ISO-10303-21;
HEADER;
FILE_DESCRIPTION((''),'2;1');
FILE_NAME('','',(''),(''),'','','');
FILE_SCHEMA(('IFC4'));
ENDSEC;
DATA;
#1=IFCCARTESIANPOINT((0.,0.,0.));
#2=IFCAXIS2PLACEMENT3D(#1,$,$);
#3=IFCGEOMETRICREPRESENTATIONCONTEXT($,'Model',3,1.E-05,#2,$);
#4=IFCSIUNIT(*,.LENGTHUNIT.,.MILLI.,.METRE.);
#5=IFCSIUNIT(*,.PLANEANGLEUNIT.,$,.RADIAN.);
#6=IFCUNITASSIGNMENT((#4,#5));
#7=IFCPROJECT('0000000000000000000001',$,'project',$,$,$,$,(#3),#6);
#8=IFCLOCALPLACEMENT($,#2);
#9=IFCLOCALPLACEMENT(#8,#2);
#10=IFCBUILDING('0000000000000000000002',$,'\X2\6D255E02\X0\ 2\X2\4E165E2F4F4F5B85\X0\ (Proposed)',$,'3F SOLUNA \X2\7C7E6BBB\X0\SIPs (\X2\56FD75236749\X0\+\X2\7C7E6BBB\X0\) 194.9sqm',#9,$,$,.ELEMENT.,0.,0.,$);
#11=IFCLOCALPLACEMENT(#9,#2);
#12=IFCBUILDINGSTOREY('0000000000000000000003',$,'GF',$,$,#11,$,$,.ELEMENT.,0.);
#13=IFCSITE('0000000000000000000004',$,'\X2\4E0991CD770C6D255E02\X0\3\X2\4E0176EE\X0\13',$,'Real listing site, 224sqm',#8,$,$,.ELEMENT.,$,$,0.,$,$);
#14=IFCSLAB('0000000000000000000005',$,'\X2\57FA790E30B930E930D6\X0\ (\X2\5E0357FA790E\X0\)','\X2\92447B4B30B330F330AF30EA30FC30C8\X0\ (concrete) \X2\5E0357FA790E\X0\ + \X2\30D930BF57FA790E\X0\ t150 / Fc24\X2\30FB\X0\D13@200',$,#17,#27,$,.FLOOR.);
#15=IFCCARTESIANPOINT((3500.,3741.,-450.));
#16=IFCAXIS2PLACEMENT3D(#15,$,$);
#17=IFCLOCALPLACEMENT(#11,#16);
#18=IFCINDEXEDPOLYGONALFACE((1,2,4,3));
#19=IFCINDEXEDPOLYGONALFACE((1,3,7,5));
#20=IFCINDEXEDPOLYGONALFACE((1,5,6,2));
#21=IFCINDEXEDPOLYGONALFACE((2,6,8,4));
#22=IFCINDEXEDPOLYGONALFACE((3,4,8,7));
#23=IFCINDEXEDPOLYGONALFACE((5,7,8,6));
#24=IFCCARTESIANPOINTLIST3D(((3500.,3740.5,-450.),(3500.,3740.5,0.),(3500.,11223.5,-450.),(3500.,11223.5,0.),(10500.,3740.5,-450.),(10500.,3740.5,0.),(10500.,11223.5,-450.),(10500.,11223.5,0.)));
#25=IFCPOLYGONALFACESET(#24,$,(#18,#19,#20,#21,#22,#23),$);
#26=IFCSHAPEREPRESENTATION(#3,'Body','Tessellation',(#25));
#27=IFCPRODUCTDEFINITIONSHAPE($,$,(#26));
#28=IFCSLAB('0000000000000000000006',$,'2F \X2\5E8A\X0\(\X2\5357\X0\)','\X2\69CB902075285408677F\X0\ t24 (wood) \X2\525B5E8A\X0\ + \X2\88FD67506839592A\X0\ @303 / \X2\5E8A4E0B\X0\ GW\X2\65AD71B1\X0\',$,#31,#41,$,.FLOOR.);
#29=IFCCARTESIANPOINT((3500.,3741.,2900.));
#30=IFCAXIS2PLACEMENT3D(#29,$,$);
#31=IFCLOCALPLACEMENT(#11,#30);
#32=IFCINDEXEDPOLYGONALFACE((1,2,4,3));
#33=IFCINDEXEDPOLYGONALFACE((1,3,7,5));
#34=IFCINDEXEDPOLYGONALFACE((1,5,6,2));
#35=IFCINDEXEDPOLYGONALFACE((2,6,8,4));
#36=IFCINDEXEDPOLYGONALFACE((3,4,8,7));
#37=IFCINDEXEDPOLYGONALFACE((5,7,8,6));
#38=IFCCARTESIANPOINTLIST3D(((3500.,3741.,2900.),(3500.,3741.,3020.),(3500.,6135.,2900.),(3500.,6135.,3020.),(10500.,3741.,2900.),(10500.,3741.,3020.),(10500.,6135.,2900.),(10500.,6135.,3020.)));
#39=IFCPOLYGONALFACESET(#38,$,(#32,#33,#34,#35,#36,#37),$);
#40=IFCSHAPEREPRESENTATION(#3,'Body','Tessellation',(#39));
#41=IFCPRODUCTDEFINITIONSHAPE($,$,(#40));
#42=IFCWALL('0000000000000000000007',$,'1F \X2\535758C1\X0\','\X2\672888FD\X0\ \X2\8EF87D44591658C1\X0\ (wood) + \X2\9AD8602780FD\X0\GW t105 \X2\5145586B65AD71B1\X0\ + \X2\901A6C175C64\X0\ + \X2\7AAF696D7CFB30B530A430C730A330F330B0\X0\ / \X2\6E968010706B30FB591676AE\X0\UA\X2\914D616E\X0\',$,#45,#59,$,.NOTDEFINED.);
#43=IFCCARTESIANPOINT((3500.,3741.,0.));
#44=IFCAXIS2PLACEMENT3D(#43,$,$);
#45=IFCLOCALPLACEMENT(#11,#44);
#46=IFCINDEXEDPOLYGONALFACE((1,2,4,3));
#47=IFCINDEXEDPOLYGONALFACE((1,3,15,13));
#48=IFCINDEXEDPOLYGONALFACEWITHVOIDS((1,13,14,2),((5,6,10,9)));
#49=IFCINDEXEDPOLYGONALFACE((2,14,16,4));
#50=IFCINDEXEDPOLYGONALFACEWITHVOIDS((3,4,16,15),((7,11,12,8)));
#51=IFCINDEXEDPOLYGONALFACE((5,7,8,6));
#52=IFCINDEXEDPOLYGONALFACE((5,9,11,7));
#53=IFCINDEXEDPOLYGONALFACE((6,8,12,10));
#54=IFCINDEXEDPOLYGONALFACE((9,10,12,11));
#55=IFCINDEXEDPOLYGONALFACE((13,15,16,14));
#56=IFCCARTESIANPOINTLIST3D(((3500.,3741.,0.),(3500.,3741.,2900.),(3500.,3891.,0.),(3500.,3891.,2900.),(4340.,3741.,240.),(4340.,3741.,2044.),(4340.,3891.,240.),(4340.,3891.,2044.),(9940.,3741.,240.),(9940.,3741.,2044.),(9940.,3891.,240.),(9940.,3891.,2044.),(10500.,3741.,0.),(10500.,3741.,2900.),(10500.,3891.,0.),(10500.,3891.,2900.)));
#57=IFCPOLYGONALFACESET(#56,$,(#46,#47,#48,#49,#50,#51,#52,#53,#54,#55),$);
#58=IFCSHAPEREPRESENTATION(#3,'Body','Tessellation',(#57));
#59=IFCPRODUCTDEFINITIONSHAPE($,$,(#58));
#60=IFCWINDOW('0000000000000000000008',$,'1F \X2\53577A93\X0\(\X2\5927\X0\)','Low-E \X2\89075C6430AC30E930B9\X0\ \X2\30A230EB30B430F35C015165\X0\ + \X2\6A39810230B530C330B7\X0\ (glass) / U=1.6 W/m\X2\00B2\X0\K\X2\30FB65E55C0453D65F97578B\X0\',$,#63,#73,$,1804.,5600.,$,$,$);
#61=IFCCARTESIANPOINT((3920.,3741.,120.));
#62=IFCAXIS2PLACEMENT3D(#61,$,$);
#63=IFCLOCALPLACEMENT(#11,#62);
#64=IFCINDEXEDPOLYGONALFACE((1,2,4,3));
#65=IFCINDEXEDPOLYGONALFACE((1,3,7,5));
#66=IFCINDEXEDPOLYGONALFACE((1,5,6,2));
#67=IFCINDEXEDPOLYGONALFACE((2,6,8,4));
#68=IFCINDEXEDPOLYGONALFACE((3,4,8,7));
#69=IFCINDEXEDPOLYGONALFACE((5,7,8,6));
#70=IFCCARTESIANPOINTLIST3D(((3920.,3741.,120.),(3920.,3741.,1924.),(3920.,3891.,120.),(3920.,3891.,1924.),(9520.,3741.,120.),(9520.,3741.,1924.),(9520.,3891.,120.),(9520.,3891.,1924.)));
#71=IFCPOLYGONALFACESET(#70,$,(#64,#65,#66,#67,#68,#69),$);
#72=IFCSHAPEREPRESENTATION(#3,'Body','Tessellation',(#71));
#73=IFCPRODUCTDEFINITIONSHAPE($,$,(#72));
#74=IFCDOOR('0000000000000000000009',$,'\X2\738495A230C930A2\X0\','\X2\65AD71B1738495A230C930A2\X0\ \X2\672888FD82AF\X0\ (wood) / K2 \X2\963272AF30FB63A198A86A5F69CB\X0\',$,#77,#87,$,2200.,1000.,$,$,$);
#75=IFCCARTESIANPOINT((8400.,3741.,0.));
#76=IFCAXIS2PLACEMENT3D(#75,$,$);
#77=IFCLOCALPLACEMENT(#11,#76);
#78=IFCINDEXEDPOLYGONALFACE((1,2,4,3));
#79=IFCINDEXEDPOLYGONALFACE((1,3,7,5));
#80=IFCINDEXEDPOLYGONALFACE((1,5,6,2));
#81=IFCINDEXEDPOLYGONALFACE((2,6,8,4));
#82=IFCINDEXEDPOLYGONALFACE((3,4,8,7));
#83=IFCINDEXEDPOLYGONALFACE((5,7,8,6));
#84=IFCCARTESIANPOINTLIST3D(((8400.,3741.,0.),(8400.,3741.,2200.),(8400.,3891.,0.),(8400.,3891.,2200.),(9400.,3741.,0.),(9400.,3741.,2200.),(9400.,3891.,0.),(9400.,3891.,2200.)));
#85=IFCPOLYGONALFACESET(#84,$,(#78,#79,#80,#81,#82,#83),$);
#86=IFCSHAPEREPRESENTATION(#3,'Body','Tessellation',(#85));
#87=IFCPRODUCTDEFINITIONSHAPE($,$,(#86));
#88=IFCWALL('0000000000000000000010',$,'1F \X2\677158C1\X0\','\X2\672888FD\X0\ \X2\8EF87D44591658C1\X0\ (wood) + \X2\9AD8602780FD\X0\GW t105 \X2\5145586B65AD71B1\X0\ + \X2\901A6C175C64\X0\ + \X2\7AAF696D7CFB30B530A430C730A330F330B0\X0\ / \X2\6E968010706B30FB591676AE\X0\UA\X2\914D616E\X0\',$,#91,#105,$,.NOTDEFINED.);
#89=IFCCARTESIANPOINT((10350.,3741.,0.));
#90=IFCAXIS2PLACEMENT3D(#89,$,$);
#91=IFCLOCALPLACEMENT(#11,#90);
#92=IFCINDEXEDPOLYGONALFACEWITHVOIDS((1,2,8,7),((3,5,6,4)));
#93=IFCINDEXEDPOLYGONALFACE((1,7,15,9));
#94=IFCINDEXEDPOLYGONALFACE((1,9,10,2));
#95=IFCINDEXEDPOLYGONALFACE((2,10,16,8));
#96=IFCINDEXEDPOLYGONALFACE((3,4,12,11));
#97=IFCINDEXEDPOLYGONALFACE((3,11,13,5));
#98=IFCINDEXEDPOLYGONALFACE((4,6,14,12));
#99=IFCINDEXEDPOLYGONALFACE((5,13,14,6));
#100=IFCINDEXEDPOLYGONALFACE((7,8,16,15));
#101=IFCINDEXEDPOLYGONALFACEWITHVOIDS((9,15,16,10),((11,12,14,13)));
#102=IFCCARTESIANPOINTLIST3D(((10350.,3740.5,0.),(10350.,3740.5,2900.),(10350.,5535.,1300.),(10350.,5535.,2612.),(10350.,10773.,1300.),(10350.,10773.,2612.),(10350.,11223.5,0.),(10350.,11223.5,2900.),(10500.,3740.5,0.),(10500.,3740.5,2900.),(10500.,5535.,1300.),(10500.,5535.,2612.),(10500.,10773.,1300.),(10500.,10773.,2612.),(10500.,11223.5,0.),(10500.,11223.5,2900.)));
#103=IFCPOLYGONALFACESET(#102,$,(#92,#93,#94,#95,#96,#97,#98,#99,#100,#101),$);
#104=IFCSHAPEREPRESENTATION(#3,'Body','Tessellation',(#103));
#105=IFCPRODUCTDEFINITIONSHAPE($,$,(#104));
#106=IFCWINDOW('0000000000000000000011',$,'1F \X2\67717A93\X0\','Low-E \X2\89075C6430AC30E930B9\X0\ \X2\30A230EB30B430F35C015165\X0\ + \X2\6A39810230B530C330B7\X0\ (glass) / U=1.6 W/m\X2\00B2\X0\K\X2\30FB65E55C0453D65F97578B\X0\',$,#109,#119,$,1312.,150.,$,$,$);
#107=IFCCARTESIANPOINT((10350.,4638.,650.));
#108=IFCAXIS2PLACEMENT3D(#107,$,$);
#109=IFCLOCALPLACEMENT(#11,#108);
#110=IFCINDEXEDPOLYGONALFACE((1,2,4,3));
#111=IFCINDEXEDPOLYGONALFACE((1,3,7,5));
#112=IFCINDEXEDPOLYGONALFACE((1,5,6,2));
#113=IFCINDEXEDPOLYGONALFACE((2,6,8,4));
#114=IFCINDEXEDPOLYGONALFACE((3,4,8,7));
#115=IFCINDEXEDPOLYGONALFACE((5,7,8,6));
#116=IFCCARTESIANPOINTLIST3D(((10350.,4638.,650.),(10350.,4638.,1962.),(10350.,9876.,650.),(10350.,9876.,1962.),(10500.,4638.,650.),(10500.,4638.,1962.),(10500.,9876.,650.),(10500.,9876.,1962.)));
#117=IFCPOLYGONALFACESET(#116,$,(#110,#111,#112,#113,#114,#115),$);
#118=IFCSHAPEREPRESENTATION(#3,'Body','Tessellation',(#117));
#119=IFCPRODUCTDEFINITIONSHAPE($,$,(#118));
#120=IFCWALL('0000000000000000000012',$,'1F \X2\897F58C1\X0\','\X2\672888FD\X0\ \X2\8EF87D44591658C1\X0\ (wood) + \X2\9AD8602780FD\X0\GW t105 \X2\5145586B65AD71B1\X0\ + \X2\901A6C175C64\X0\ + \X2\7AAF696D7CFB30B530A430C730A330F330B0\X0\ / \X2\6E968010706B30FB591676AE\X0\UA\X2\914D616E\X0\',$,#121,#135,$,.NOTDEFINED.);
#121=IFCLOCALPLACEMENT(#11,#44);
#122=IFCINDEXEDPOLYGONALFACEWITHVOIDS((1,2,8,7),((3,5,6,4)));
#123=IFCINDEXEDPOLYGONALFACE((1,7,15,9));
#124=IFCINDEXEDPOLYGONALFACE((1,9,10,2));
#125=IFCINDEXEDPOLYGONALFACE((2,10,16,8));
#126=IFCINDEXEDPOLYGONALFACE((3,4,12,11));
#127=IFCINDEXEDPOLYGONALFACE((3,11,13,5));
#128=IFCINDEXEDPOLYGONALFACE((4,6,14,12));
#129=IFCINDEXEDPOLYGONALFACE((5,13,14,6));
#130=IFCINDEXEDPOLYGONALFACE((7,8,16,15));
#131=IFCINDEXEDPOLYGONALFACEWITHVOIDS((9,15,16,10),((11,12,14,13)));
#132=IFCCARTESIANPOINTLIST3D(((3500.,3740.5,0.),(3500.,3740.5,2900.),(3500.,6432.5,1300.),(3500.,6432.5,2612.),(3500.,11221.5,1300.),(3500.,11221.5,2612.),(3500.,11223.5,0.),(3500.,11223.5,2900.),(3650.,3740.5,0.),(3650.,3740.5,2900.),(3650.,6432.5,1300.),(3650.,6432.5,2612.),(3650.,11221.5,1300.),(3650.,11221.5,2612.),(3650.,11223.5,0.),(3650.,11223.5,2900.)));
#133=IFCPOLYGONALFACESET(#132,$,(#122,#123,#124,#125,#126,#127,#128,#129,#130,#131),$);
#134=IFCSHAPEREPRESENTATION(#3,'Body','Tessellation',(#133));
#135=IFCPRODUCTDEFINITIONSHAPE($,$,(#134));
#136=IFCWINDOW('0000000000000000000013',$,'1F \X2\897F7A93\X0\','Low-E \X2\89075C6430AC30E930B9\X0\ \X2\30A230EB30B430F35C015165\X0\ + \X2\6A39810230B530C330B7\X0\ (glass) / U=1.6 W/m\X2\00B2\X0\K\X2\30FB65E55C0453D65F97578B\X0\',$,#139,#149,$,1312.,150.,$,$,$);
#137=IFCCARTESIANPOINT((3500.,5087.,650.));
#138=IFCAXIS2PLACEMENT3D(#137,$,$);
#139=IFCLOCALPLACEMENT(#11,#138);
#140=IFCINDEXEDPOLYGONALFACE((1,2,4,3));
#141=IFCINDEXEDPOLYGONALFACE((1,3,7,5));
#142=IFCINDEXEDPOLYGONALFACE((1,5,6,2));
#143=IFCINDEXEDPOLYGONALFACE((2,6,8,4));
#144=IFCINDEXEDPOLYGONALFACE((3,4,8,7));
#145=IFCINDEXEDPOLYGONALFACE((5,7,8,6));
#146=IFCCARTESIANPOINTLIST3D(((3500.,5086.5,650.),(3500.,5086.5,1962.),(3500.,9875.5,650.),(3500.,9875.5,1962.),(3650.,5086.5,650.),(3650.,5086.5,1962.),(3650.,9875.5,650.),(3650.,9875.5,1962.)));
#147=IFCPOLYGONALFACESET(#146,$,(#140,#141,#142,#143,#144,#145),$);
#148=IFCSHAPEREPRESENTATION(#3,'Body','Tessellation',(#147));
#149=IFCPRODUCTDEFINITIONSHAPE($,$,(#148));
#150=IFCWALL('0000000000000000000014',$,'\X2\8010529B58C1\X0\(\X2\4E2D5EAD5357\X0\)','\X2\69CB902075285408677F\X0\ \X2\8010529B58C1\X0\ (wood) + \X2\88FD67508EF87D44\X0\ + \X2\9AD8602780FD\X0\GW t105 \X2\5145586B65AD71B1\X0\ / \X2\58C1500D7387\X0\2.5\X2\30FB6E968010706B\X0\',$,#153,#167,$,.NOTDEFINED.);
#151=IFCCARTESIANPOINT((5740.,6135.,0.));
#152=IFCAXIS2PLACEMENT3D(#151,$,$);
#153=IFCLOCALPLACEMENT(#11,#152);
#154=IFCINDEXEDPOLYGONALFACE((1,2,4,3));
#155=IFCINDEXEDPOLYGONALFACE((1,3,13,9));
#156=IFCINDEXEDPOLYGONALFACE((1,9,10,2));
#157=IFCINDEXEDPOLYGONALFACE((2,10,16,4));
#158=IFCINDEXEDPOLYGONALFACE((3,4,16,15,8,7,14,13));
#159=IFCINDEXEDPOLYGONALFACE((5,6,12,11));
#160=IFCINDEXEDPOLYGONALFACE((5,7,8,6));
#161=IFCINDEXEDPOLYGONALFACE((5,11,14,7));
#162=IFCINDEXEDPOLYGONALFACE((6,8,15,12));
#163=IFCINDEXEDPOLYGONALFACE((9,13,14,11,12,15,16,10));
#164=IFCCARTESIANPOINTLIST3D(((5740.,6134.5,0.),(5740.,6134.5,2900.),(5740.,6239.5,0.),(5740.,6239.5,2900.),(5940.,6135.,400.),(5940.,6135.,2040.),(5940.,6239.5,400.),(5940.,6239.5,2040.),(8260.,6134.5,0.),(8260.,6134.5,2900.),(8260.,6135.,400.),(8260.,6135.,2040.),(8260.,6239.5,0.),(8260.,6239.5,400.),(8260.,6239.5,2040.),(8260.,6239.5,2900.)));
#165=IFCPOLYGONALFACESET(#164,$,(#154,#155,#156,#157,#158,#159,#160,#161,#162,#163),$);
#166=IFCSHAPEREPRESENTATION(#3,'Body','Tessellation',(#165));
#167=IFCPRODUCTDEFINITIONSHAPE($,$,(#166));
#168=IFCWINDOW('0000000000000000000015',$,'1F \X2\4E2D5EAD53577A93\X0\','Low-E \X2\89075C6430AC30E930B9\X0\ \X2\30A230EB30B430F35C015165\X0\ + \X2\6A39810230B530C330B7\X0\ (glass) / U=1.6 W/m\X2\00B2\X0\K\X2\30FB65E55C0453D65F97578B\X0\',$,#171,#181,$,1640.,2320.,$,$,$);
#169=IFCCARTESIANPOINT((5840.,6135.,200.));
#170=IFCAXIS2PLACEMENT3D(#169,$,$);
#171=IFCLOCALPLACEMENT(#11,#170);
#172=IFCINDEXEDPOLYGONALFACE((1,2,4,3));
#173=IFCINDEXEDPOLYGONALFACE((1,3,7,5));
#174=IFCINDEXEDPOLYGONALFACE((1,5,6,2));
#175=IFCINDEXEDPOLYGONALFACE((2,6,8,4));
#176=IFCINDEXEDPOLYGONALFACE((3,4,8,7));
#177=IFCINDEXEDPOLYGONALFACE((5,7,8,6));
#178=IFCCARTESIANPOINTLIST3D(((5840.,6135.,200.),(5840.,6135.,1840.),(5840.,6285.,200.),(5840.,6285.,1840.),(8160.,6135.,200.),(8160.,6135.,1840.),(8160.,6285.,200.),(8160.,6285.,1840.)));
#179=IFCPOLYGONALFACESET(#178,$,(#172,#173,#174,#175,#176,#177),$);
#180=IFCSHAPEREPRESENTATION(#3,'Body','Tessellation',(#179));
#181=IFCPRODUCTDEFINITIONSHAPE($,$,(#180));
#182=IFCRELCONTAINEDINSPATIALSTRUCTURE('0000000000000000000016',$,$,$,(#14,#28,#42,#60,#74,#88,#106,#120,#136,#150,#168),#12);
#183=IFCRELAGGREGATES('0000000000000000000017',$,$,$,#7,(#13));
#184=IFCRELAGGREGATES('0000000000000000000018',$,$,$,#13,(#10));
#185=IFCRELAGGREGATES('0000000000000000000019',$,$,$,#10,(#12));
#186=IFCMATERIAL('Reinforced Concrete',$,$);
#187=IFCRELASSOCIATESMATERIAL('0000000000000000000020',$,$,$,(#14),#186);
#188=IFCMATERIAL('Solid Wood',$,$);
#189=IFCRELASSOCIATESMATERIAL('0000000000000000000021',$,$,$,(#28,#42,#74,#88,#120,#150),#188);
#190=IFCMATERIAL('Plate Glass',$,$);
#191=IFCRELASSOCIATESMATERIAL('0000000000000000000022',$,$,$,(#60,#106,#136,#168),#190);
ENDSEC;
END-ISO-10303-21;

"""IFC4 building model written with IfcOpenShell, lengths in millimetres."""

from ifc_helpers import new_model, si_unit, frame, frame_2d, origin, place, context, project, spatial, rectangle, extrude, material, element, fill, save


model = new_model("IFC4")

# Units and contexts
model_context = context("Model", 3, precision=1e-05, world=origin())
ifc_project = project(units=[si_unit("LENGTHUNIT", "METRE", prefix="MILLI"), si_unit("PLANEANGLEUNIT", "RADIAN")], contexts=[model_context])

# Site, building, storey
site_placement = place(None, origin())
site = spatial("IfcSite", under=ifc_project, at=site_placement, Name="三重県津市3丁目13", ObjectType="Real listing site, 224sqm", CompositionType="ELEMENT", RefElevation=0.0)
building_placement = place(site_placement, origin())
building = spatial("IfcBuilding", under=site, at=building_placement, Name="津市 2世帯住宅 (Proposed)", ObjectType="3F SOLUNA 籾殻SIPs (国産杉+籾殻) 194.9sqm", CompositionType="ELEMENT", ElevationOfRefHeight=0.0, ElevationOfTerrain=0.0)
storey_placement = place(building_placement, origin())
storey = spatial("IfcBuildingStorey", under=building, at=storey_placement, Name="GF", CompositionType="ELEMENT", Elevation=0.0)

# Slabs
ifc_material_1 = material(Name="Reinforced Concrete")
slab_1_placement = place(storey_placement, frame((3500.0, 3741.0, -450.0)))
element("IfcSlab", 1, at=slab_1_placement, inside=storey, material=ifc_material_1, Name="基礎スラブ (布基礎)", Description="鉄筋コンクリート (concrete) 布基礎 + ベタ基礎 t150 / Fc24・D13@200", PredefinedType="FLOOR", context=model_context, shape_type="SweptSolid", body=[
    extrude(rectangle(XDim=7000.0, YDim=7483.0, at=frame_2d((3500.0, 3741.0))), frame((3500.0, 3741.0, -450.0)), (0.0, 0.0, 1.0), 450.0),
])
ifc_material_2 = material(Name="Solid Wood")
slab_2_placement = place(storey_placement, frame((3500.0, 3741.0, 2900.0)))
element("IfcSlab", 2, at=slab_2_placement, inside=storey, material=ifc_material_2, Name="2F 床(南)", Description="構造用合板 t24 (wood) 剛床 + 製材根太 @303 / 床下 GW断熱", PredefinedType="FLOOR", context=model_context, shape_type="SweptSolid", body=[
    extrude(rectangle(XDim=7000.0, YDim=2394.0, at=frame_2d((3500.0, 1197.0))), frame((3500.0, 3741.0, 2900.0)), (0.0, 0.0, 1.0), 120.0),
])

# Wall, openings, window, door
wall_1_placement = place(storey_placement, frame((3500.0, 3741.0, 0.0)))
wall_1 = element("IfcWall", 3, at=wall_1_placement, inside=storey, material=ifc_material_2, Name="1F 南壁", Description="木製 軸組外壁 (wood) + 高性能GW t105 充填断熱 + 通気層 + 窯業系サイディング / 準耐火・外皮UA配慮", PredefinedType="NOTDEFINED", context=model_context, shape_type="SweptSolid", body=[
    extrude(rectangle(XDim=7000.0, YDim=150.0, at=frame_2d((3500.0, 75.0))), frame((3500.0, 3741.0, 0.0)), (0.0, 0.0, 1.0), 2900.0),
])
opening_1_placement = place(storey_placement, frame((3920.0, 3741.0, 120.0)))
opening_1 = element("IfcOpeningElement", 4, at=opening_1_placement, cuts=wall_1, PredefinedType="NOTDEFINED", context=model_context, shape_type="SweptSolid", body=[
    extrude(rectangle(XDim=5600.0, YDim=150.0, at=frame_2d((2800.0, 75.0))), frame((3920.0, 3741.0, 120.0)), (0.0, 0.0, 1.0), 1804.0),
])
opening_2_placement = place(storey_placement, frame((8400.0, 3741.0, 0.0)))
opening_2 = element("IfcOpeningElement", 5, at=opening_2_placement, cuts=wall_1, PredefinedType="NOTDEFINED", context=model_context, shape_type="SweptSolid", body=[
    extrude(rectangle(XDim=1000.0, YDim=150.0, at=frame_2d((500.0, 75.0))), frame((8400.0, 3741.0, 0.0)), (0.0, 0.0, 1.0), 2200.0),
])
ifc_material_3 = material(Name="Plate Glass")
window_1_placement = place(storey_placement, frame((3920.0, 3741.0, 120.0)))
window_1 = element("IfcWindow", 6, at=window_1_placement, inside=storey, material=ifc_material_3, Name="1F 南窓(大)", Description="Low-E 複層ガラス アルゴン封入 + 樹脂サッシ (glass) / U=1.6 W/m²K・日射取得型", OverallHeight=1804.0, OverallWidth=5600.0, context=model_context, shape_type="SweptSolid", body=[
    extrude(rectangle(XDim=5600.0, YDim=150.0, at=frame_2d((2800.0, 75.0))), frame((3920.0, 3741.0, 120.0)), (0.0, 0.0, 1.0), 1804.0),
])
fill(opening_1, window_1)
door_placement = place(storey_placement, frame((8400.0, 3741.0, 0.0)))
door = element("IfcDoor", 7, at=door_placement, inside=storey, material=ifc_material_2, Name="玄関ドア", Description="断熱玄関ドア 木製芯 (wood) / K2 防犯・採風機構", OverallHeight=2200.0, OverallWidth=1000.0, context=model_context, shape_type="SweptSolid", body=[
    extrude(rectangle(XDim=1000.0, YDim=150.0, at=frame_2d((500.0, 75.0))), frame((8400.0, 3741.0, 0.0)), (0.0, 0.0, 1.0), 2200.0),
])
fill(opening_2, door)

# Walls, openings, windows
wall_2_placement = place(storey_placement, frame((10350.0, 3741.0, 0.0)))
wall_2 = element("IfcWall", 8, at=wall_2_placement, inside=storey, material=ifc_material_2, Name="1F 東壁", Description="木製 軸組外壁 (wood) + 高性能GW t105 充填断熱 + 通気層 + 窯業系サイディング / 準耐火・外皮UA配慮", PredefinedType="NOTDEFINED", context=model_context, shape_type="SweptSolid", body=[
    extrude(rectangle(XDim=150.0, YDim=7483.0, at=frame_2d((75.0, 3741.0))), frame((10350.0, 3741.0, 0.0)), (0.0, 0.0, 1.0), 2900.0),
])
opening_3_placement = place(storey_placement, frame((10350.0, 4638.0, 650.0)))
opening_3 = element("IfcOpeningElement", 9, at=opening_3_placement, cuts=wall_2, PredefinedType="NOTDEFINED", context=model_context, shape_type="SweptSolid", body=[
    extrude(rectangle(XDim=150.0, YDim=5238.0, at=frame_2d((75.0, 2619.0))), frame((10350.0, 4638.0, 650.0)), (0.0, 0.0, 1.0), 1312.0),
])
window_2_placement = place(storey_placement, frame((10350.0, 4638.0, 650.0)))
window_2 = element("IfcWindow", 10, at=window_2_placement, inside=storey, material=ifc_material_3, Name="1F 東窓", Description="Low-E 複層ガラス アルゴン封入 + 樹脂サッシ (glass) / U=1.6 W/m²K・日射取得型", OverallHeight=1312.0, OverallWidth=150.0, context=model_context, shape_type="SweptSolid", body=[
    extrude(rectangle(XDim=150.0, YDim=5238.0, at=frame_2d((75.0, 2619.0))), frame((10350.0, 4638.0, 650.0)), (0.0, 0.0, 1.0), 1312.0),
])
fill(opening_3, window_2)
wall_3_placement = place(storey_placement, frame((3500.0, 3741.0, 0.0)))
wall_3 = element("IfcWall", 11, at=wall_3_placement, inside=storey, material=ifc_material_2, Name="1F 西壁", Description="木製 軸組外壁 (wood) + 高性能GW t105 充填断熱 + 通気層 + 窯業系サイディング / 準耐火・外皮UA配慮", PredefinedType="NOTDEFINED", context=model_context, shape_type="SweptSolid", body=[
    extrude(rectangle(XDim=150.0, YDim=7483.0, at=frame_2d((75.0, 3741.0))), frame((3500.0, 3741.0, 0.0)), (0.0, 0.0, 1.0), 2900.0),
])
opening_4_placement = place(storey_placement, frame((3500.0, 5087.0, 650.0)))
opening_4 = element("IfcOpeningElement", 12, at=opening_4_placement, cuts=wall_3, PredefinedType="NOTDEFINED", context=model_context, shape_type="SweptSolid", body=[
    extrude(rectangle(XDim=150.0, YDim=4789.0, at=frame_2d((75.0, 2394.0))), frame((3500.0, 5087.0, 650.0)), (0.0, 0.0, 1.0), 1312.0),
])
window_3_placement = place(storey_placement, frame((3500.0, 5087.0, 650.0)))
window_3 = element("IfcWindow", 13, at=window_3_placement, inside=storey, material=ifc_material_3, Name="1F 西窓", Description="Low-E 複層ガラス アルゴン封入 + 樹脂サッシ (glass) / U=1.6 W/m²K・日射取得型", OverallHeight=1312.0, OverallWidth=150.0, context=model_context, shape_type="SweptSolid", body=[
    extrude(rectangle(XDim=150.0, YDim=4789.0, at=frame_2d((75.0, 2394.0))), frame((3500.0, 5087.0, 650.0)), (0.0, 0.0, 1.0), 1312.0),
])
fill(opening_4, window_3)
wall_4_placement = place(storey_placement, frame((5740.0, 6135.0, 0.0)))
wall_4 = element("IfcWall", 14, at=wall_4_placement, inside=storey, material=ifc_material_2, Name="耐力壁(中庭南)", Description="構造用合板 耐力壁 (wood) + 製材軸組 + 高性能GW t105 充填断熱 / 壁倍率2.5・準耐火", PredefinedType="NOTDEFINED", context=model_context, shape_type="SweptSolid", body=[
    extrude(rectangle(XDim=2520.0, YDim=105.0, at=frame_2d((1260.0, 52.0))), frame((5740.0, 6135.0, 0.0)), (0.0, 0.0, 1.0), 2900.0),
])
opening_5_placement = place(storey_placement, frame((5840.0, 6135.0, 200.0)))
opening_5 = element("IfcOpeningElement", 15, at=opening_5_placement, cuts=wall_4, PredefinedType="NOTDEFINED", context=model_context, shape_type="SweptSolid", body=[
    extrude(rectangle(XDim=2320.0, YDim=150.0, at=frame_2d((1160.0, 75.0))), frame((5840.0, 6135.0, 200.0)), (0.0, 0.0, 1.0), 1640.0),
])
window_4_placement = place(storey_placement, frame((5840.0, 6135.0, 200.0)))
window_4 = element("IfcWindow", 16, at=window_4_placement, inside=storey, material=ifc_material_3, Name="1F 中庭南窓", Description="Low-E 複層ガラス アルゴン封入 + 樹脂サッシ (glass) / U=1.6 W/m²K・日射取得型", OverallHeight=1640.0, OverallWidth=2320.0, context=model_context, shape_type="SweptSolid", body=[
    extrude(rectangle(XDim=2320.0, YDim=150.0, at=frame_2d((1160.0, 75.0))), frame((5840.0, 6135.0, 200.0)), (0.0, 0.0, 1.0), 1640.0),
])
fill(opening_5, window_4)

save(model, "model.ifc")
